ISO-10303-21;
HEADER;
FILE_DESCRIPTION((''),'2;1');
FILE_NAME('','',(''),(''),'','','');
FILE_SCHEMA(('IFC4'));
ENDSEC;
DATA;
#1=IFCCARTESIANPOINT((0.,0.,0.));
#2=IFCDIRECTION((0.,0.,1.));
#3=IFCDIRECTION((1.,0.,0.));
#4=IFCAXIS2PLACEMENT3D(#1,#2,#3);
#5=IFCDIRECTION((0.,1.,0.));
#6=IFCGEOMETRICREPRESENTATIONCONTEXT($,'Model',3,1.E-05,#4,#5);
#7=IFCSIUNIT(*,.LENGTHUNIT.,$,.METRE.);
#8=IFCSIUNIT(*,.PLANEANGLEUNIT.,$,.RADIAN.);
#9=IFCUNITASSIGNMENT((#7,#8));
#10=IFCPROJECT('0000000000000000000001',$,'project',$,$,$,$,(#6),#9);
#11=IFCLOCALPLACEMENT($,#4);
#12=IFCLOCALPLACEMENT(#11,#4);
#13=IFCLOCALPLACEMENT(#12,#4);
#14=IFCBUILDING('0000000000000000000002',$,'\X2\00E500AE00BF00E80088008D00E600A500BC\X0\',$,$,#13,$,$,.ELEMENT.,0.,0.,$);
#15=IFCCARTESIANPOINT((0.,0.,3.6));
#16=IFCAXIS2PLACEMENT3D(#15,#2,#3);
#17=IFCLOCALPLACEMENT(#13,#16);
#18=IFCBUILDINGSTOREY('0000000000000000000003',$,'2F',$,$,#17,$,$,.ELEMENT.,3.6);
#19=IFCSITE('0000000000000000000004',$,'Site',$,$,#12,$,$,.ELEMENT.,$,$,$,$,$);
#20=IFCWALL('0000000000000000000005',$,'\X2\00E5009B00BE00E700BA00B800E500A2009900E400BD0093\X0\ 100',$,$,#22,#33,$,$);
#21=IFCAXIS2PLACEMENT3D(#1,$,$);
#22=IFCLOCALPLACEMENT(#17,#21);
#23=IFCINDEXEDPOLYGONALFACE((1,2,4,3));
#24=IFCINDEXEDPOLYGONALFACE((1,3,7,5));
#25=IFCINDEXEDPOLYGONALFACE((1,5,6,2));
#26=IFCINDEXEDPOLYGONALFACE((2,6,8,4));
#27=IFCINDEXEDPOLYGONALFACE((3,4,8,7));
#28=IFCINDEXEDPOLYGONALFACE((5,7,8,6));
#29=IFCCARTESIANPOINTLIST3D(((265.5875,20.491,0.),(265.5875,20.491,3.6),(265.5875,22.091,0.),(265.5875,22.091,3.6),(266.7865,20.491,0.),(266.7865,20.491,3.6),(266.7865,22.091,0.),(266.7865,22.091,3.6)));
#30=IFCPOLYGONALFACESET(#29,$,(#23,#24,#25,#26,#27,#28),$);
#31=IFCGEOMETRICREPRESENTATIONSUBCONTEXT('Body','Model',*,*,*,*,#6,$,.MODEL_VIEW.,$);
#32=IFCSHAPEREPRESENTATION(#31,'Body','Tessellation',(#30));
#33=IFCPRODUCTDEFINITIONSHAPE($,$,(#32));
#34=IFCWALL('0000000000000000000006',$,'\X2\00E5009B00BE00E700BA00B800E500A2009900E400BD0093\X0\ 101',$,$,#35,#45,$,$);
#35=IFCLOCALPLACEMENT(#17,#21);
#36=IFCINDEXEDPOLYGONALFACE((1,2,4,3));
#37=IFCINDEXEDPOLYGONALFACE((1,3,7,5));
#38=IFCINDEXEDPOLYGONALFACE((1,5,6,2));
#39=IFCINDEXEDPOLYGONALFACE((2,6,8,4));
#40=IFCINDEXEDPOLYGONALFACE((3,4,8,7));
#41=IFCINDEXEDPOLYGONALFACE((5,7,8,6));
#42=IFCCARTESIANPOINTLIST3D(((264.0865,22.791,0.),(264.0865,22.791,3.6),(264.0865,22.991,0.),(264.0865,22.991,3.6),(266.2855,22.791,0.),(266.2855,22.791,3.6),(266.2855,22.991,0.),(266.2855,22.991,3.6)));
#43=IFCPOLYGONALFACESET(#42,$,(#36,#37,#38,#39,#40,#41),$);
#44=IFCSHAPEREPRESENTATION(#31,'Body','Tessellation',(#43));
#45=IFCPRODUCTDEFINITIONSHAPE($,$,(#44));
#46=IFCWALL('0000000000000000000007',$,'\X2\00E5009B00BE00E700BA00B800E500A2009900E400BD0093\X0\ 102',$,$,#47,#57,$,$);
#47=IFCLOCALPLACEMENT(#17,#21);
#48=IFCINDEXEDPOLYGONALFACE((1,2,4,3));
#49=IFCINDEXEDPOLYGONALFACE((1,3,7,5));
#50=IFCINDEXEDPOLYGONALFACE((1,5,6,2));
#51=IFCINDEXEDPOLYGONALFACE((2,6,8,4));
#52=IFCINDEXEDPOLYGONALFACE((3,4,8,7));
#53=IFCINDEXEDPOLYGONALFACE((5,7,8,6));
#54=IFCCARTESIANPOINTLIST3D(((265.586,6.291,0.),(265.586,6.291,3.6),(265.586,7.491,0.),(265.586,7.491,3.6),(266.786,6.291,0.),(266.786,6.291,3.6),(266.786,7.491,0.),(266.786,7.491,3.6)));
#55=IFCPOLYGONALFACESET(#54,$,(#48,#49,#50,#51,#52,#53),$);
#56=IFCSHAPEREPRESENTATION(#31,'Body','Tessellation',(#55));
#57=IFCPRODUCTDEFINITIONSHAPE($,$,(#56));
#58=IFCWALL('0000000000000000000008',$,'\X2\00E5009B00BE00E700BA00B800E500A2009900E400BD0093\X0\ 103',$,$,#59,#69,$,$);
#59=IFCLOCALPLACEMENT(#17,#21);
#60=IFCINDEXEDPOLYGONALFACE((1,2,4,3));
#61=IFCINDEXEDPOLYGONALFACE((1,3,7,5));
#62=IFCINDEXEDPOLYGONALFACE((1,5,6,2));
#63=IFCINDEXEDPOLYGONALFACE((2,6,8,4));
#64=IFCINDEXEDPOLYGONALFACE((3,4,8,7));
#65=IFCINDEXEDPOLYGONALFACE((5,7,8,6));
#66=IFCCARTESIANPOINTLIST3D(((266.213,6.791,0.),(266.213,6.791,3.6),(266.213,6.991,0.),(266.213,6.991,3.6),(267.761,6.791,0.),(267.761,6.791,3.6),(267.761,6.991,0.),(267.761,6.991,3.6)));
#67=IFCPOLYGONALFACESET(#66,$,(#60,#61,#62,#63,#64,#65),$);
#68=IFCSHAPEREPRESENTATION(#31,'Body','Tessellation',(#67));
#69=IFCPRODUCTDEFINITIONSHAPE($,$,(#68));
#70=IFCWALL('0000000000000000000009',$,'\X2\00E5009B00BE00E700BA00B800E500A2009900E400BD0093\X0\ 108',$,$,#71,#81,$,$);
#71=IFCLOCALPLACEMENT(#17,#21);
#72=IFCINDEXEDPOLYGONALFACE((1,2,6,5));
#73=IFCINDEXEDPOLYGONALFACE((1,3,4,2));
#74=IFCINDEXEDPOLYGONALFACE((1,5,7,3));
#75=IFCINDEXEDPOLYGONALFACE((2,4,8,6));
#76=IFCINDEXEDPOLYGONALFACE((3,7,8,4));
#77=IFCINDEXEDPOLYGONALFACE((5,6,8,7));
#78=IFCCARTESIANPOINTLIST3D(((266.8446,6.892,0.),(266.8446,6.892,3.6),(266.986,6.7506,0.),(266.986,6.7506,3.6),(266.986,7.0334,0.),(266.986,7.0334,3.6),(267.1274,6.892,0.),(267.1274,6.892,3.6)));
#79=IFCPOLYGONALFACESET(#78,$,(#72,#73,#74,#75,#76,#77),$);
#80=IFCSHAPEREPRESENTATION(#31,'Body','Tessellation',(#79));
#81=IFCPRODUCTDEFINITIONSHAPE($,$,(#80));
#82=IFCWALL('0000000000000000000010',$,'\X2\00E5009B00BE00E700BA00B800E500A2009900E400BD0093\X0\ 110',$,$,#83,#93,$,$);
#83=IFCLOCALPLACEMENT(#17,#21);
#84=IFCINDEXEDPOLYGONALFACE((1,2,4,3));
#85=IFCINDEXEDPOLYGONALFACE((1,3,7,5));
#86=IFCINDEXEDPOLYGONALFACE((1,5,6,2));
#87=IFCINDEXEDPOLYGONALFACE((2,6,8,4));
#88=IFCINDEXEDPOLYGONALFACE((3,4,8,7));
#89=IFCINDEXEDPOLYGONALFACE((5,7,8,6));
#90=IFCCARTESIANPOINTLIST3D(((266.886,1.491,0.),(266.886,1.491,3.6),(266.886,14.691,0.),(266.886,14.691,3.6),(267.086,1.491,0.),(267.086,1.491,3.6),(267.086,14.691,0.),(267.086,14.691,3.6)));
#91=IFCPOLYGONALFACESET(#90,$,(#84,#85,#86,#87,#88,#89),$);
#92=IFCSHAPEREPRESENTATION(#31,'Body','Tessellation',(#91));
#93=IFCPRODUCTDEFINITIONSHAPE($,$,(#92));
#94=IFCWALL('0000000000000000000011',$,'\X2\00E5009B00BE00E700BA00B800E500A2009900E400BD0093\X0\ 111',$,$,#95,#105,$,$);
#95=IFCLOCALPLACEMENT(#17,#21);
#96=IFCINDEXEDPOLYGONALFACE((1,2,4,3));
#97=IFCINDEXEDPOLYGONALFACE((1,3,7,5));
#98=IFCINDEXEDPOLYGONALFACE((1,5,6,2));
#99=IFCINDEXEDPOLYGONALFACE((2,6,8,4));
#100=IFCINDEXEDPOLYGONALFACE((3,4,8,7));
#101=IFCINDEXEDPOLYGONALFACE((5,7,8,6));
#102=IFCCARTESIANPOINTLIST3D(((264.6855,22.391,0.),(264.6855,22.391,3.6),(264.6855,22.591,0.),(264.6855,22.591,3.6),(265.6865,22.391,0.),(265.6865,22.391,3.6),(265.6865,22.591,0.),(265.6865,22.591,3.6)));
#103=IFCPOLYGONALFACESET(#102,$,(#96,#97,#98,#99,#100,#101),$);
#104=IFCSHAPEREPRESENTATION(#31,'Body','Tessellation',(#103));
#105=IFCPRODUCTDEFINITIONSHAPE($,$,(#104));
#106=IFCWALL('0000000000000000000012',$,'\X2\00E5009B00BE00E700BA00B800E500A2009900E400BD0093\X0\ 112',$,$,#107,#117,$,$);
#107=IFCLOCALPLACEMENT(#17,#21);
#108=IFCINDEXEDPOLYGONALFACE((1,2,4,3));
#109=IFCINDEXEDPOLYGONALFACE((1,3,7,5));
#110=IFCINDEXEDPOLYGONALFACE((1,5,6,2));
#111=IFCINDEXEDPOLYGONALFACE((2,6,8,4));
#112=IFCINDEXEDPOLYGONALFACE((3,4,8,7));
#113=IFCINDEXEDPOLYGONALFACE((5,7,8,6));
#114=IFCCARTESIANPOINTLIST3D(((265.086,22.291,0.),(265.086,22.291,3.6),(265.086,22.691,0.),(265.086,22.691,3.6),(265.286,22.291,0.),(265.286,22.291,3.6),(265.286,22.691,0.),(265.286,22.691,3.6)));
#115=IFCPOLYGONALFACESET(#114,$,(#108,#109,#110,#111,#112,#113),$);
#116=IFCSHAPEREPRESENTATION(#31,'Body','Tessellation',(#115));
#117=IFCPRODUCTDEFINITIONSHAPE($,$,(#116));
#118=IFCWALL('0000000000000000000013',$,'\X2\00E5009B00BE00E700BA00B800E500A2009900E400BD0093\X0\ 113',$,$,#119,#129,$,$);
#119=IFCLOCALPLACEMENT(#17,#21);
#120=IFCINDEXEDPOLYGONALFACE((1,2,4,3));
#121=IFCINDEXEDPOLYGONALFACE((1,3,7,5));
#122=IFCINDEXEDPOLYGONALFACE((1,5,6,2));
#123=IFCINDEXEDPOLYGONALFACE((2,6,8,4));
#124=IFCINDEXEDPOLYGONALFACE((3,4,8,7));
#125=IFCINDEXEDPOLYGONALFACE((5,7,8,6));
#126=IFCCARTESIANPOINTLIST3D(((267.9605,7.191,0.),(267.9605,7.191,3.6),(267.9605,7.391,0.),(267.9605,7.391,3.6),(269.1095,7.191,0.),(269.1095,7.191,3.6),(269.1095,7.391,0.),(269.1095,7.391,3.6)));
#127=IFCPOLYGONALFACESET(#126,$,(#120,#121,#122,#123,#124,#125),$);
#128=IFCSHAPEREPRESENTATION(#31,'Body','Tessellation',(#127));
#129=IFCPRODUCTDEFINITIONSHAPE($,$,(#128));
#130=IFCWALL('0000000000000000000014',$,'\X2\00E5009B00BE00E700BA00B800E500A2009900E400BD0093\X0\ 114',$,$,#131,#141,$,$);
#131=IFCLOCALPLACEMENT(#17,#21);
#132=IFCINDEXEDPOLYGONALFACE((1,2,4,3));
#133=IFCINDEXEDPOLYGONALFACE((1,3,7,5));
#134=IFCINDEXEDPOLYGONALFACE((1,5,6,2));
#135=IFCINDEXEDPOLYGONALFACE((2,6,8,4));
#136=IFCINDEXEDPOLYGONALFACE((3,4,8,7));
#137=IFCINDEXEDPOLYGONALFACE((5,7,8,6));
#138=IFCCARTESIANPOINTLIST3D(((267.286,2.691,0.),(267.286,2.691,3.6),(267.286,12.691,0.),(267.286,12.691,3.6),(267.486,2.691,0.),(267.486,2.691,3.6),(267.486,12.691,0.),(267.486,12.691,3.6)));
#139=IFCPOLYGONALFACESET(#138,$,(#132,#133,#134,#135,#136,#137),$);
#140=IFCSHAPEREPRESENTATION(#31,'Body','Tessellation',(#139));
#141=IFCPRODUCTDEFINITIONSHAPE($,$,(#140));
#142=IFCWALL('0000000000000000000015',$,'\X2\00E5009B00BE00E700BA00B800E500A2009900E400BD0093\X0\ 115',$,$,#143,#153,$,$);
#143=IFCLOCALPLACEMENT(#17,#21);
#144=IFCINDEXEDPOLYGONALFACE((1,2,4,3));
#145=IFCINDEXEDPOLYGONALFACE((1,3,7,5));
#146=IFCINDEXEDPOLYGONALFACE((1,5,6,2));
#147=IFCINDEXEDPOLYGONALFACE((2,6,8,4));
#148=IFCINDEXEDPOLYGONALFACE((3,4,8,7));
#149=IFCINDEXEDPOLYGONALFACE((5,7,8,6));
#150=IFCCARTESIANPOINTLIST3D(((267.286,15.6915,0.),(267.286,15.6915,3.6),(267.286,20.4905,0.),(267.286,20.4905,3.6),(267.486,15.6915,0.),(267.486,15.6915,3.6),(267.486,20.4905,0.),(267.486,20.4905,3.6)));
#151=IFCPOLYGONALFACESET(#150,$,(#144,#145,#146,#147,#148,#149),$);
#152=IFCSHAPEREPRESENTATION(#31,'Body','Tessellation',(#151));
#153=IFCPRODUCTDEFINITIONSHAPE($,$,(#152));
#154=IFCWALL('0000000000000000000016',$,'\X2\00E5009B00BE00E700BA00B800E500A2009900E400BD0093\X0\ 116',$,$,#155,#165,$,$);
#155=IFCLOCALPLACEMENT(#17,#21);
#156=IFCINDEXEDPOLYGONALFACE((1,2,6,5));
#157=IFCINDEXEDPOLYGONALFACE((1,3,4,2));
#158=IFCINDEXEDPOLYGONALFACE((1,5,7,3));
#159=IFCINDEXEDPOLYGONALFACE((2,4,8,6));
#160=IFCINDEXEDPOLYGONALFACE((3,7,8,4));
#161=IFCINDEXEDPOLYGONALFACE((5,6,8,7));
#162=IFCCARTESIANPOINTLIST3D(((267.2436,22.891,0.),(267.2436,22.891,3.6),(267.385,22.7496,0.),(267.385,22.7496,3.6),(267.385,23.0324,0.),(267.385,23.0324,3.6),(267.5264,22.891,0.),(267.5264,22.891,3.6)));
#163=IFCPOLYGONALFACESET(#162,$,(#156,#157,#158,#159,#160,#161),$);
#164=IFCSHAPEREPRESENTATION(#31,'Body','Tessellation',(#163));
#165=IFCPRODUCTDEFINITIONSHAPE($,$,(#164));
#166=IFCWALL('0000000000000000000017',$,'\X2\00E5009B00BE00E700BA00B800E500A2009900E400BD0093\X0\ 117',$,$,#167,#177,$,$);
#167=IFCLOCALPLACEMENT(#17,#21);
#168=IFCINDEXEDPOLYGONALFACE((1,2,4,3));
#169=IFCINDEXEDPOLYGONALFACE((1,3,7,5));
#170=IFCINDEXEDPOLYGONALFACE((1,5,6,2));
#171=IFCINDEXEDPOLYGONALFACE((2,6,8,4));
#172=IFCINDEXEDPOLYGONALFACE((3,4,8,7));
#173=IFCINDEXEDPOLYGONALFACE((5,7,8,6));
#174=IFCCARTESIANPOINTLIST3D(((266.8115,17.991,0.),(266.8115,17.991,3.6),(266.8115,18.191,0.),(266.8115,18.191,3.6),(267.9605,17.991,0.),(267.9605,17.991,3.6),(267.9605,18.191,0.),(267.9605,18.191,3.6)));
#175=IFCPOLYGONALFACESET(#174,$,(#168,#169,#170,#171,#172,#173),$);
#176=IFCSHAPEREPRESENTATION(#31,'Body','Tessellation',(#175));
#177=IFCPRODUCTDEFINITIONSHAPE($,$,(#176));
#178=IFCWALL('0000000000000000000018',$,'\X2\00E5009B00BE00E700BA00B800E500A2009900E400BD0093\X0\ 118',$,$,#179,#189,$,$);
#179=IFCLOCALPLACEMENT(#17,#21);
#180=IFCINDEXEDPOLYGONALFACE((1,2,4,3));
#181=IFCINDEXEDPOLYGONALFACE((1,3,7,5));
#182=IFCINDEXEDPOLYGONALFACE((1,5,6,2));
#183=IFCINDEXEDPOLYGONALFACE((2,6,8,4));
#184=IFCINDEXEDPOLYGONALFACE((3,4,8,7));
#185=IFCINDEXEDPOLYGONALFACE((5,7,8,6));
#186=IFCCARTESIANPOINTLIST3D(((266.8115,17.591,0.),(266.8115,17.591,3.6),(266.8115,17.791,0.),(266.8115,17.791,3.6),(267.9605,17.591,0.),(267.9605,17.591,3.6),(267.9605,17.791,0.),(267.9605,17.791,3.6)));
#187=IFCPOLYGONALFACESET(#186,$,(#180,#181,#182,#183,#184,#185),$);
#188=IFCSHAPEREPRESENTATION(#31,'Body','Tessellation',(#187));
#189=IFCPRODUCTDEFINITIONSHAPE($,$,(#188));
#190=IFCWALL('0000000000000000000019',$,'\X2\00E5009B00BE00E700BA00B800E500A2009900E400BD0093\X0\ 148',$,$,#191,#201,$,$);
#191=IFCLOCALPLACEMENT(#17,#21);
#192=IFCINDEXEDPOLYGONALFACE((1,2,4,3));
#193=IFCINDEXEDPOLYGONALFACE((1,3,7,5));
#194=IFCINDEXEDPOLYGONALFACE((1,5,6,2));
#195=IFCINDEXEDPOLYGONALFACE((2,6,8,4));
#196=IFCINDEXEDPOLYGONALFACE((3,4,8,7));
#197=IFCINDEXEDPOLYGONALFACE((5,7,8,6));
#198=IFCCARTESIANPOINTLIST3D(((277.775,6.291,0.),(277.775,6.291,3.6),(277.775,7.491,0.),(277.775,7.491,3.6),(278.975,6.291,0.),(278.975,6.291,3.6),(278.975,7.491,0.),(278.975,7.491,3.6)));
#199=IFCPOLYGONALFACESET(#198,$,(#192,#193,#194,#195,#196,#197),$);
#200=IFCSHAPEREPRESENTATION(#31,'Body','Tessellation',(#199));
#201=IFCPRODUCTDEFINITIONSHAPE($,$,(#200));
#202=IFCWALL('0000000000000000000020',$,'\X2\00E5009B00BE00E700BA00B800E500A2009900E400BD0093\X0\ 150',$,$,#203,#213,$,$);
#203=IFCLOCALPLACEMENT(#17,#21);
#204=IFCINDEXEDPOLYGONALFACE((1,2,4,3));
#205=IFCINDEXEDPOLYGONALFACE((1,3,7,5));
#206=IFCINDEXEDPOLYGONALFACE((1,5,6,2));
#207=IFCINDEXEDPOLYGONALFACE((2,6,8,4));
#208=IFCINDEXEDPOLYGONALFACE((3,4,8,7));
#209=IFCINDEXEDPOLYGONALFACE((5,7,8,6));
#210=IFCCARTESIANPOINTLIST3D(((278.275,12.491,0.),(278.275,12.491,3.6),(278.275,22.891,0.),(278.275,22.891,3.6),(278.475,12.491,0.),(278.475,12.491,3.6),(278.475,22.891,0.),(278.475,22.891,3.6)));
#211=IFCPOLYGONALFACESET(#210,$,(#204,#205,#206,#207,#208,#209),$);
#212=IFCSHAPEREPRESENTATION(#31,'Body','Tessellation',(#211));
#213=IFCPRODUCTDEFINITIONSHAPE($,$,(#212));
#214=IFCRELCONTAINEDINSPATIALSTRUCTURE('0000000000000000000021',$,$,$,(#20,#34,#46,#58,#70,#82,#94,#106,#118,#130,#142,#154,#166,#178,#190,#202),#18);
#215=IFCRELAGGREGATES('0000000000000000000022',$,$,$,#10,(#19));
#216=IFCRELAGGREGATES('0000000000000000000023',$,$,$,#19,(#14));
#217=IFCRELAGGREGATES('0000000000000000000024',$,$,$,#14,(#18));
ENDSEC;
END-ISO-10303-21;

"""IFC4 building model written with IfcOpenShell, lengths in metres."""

from ifc_helpers import new_model, si_unit, direction, frame, frame_2d, origin_with_axes, place, context, subcontext, project, spatial, rectangle, extrude, element, save


model = new_model("IFC4")

# Units and contexts
model_context = context("Model", 3, precision=1e-05, world=origin_with_axes(), true_north=direction((0.0, 1.0, 0.0)))
body_context = subcontext(model_context, "Body", "Model", "MODEL_VIEW")
ifc_project = project(units=[si_unit("LENGTHUNIT", "METRE"), si_unit("PLANEANGLEUNIT", "RADIAN")], contexts=[model_context])

# Site, building, storey
placement = place(None, origin_with_axes())
site_placement = place(placement, origin_with_axes())
site = spatial("IfcSite", under=ifc_project, at=site_placement, Name="Site", CompositionType="ELEMENT")
building_placement = place(site_placement, origin_with_axes())
building = spatial("IfcBuilding", under=site, at=building_placement, Name="å®¿è\u0088\u008dæ¥¼", CompositionType="ELEMENT", ElevationOfRefHeight=0.0, ElevationOfTerrain=0.0)
storey_placement = place(building_placement, frame((0.0, 0.0, 3.6), z_axis=(0.0, 0.0, 1.0), x_axis=(1.0, 0.0, 0.0)))
storey = spatial("IfcBuildingStorey", under=building, at=storey_placement, Name="2F", CompositionType="ELEMENT", Elevation=3.6)

# Walls
wall_1_placement = place(storey_placement, frame((266.187, 21.291, 0.0), z_axis=(0.0, 0.0, 1.0), x_axis=(1.0, 0.0, 0.0)))
element("IfcWall", 1, at=wall_1_placement, inside=storey, Name="å\u009b¾çº¸å¢\u0099ä½\u0093 100", context=body_context, shape_type="SweptSolid", body=[
    extrude(rectangle(XDim=1.199, YDim=1.6, at=frame_2d((0.0, 0.0), x_axis=(1.0, 0.0, 0.0))), frame((0.0, 0.0, 0.0), z_axis=(0.0, 0.0, 1.0)), (0.0, 0.0, 1.0), 3.6),
])
wall_2_placement = place(storey_placement, frame((265.186, 22.891, 0.0), z_axis=(0.0, 0.0, 1.0), x_axis=(1.0, 0.0, 0.0)))
element("IfcWall", 2, at=wall_2_placement, inside=storey, Name="å\u009b¾çº¸å¢\u0099ä½\u0093 101", context=body_context, shape_type="SweptSolid", body=[
    extrude(rectangle(XDim=2.199, YDim=0.2, at=frame_2d((0.0, 0.0), x_axis=(1.0, 0.0, 0.0))), frame((0.0, 0.0, 0.0), z_axis=(0.0, 0.0, 1.0)), (0.0, 0.0, 1.0), 3.6),
])
wall_3_placement = place(storey_placement, frame((266.186, 6.891, 0.0), z_axis=(0.0, 0.0, 1.0), x_axis=(1.0, 0.0, 0.0)))
element("IfcWall", 3, at=wall_3_placement, inside=storey, Name="å\u009b¾çº¸å¢\u0099ä½\u0093 102", context=body_context, shape_type="SweptSolid", body=[
    extrude(rectangle(XDim=1.2, YDim=1.2, at=frame_2d((0.0, 0.0), x_axis=(1.0, 0.0, 0.0))), frame((0.0, 0.0, 0.0), z_axis=(0.0, 0.0, 1.0)), (0.0, 0.0, 1.0), 3.6),
])
wall_4_placement = place(storey_placement, frame((266.987, 6.891, 0.0), z_axis=(0.0, 0.0, 1.0), x_axis=(1.0, 0.0, 0.0)))
element("IfcWall", 4, at=wall_4_placement, inside=storey, Name="å\u009b¾çº¸å¢\u0099ä½\u0093 103", context=body_context, shape_type="SweptSolid", body=[
    extrude(rectangle(XDim=1.548, YDim=0.2, at=frame_2d((0.0, 0.0), x_axis=(1.0, 0.0, 0.0))), frame((0.0, 0.0, 0.0), z_axis=(0.0, 0.0, 1.0)), (0.0, 0.0, 1.0), 3.6),
])
wall_5_placement = place(storey_placement, frame((266.986, 6.892, 0.0), z_axis=(0.0, 0.0, 1.0), x_axis=(0.707107, -0.707107, 0.0)))
element("IfcWall", 5, at=wall_5_placement, inside=storey, Name="å\u009b¾çº¸å¢\u0099ä½\u0093 108", context=body_context, shape_type="SweptSolid", body=[
    extrude(rectangle(XDim=0.2, YDim=0.2, at=frame_2d((0.0, 0.0), x_axis=(1.0, 0.0, 0.0))), frame((0.0, 0.0, 0.0), z_axis=(0.0, 0.0, 1.0)), (0.0, 0.0, 1.0), 3.6),
])
wall_6_placement = place(storey_placement, frame((266.986, 8.091, 0.0), z_axis=(0.0, 0.0, 1.0), x_axis=(0.0, 1.0, 0.0)))
element("IfcWall", 6, at=wall_6_placement, inside=storey, Name="å\u009b¾çº¸å¢\u0099ä½\u0093 110", context=body_context, shape_type="SweptSolid", body=[
    extrude(rectangle(XDim=13.2, YDim=0.2, at=frame_2d((0.0, 0.0), x_axis=(1.0, 0.0, 0.0))), frame((0.0, 0.0, 0.0), z_axis=(0.0, 0.0, 1.0)), (0.0, 0.0, 1.0), 3.6),
])
wall_7_placement = place(storey_placement, frame((265.186, 22.491, 0.0), z_axis=(0.0, 0.0, 1.0), x_axis=(1.0, 0.0, 0.0)))
element("IfcWall", 7, at=wall_7_placement, inside=storey, Name="å\u009b¾çº¸å¢\u0099ä½\u0093 111", context=body_context, shape_type="SweptSolid", body=[
    extrude(rectangle(XDim=1.001, YDim=0.2, at=frame_2d((0.0, 0.0), x_axis=(1.0, 0.0, 0.0))), frame((0.0, 0.0, 0.0), z_axis=(0.0, 0.0, 1.0)), (0.0, 0.0, 1.0), 3.6),
])
wall_8_placement = place(storey_placement, frame((265.186, 22.491, 0.0), z_axis=(0.0, 0.0, 1.0), x_axis=(0.0, 1.0, 0.0)))
element("IfcWall", 8, at=wall_8_placement, inside=storey, Name="å\u009b¾çº¸å¢\u0099ä½\u0093 112", context=body_context, shape_type="SweptSolid", body=[
    extrude(rectangle(XDim=0.4, YDim=0.2, at=frame_2d((0.0, 0.0), x_axis=(1.0, 0.0, 0.0))), frame((0.0, 0.0, 0.0), z_axis=(0.0, 0.0, 1.0)), (0.0, 0.0, 1.0), 3.6),
])
wall_9_placement = place(storey_placement, frame((268.535, 7.291, 0.0), z_axis=(0.0, 0.0, 1.0), x_axis=(-1.0, 0.0, 0.0)))
element("IfcWall", 9, at=wall_9_placement, inside=storey, Name="å\u009b¾çº¸å¢\u0099ä½\u0093 113", context=body_context, shape_type="SweptSolid", body=[
    extrude(rectangle(XDim=1.149, YDim=0.2, at=frame_2d((0.0, 0.0), x_axis=(1.0, 0.0, 0.0))), frame((0.0, 0.0, 0.0), z_axis=(0.0, 0.0, 1.0)), (0.0, 0.0, 1.0), 3.6),
])
wall_10_placement = place(storey_placement, frame((267.386, 7.691, 0.0), z_axis=(0.0, 0.0, 1.0), x_axis=(0.0, 1.0, 0.0)))
element("IfcWall", 10, at=wall_10_placement, inside=storey, Name="å\u009b¾çº¸å¢\u0099ä½\u0093 114", context=body_context, shape_type="SweptSolid", body=[
    extrude(rectangle(XDim=10.0, YDim=0.2, at=frame_2d((0.0, 0.0), x_axis=(1.0, 0.0, 0.0))), frame((0.0, 0.0, 0.0), z_axis=(0.0, 0.0, 1.0)), (0.0, 0.0, 1.0), 3.6),
])
wall_11_placement = place(storey_placement, frame((267.386, 18.091, 0.0), z_axis=(0.0, 0.0, 1.0), x_axis=(0.0, 1.0, 0.0)))
element("IfcWall", 11, at=wall_11_placement, inside=storey, Name="å\u009b¾çº¸å¢\u0099ä½\u0093 115", context=body_context, shape_type="SweptSolid", body=[
    extrude(rectangle(XDim=4.799, YDim=0.2, at=frame_2d((0.0, 0.0), x_axis=(1.0, 0.0, 0.0))), frame((0.0, 0.0, 0.0), z_axis=(0.0, 0.0, 1.0)), (0.0, 0.0, 1.0), 3.6),
])
wall_12_placement = place(storey_placement, frame((267.385, 22.891, 0.0), z_axis=(0.0, 0.0, 1.0), x_axis=(0.707107, -0.707107, 0.0)))
element("IfcWall", 12, at=wall_12_placement, inside=storey, Name="å\u009b¾çº¸å¢\u0099ä½\u0093 116", context=body_context, shape_type="SweptSolid", body=[
    extrude(rectangle(XDim=0.2, YDim=0.2, at=frame_2d((0.0, 0.0), x_axis=(1.0, 0.0, 0.0))), frame((0.0, 0.0, 0.0), z_axis=(0.0, 0.0, 1.0)), (0.0, 0.0, 1.0), 3.6),
])
for number, where, z_axis, x_axis, name in (
    (13, (267.386, 18.091, 0.0), (0.0, 0.0, 1.0), (1.0, 0.0, 0.0), "å\u009b¾çº¸å¢\u0099ä½\u0093 117"),
    (14, (267.386, 17.691, 0.0), (0.0, 0.0, 1.0), (1.0, 0.0, 0.0), "å\u009b¾çº¸å¢\u0099ä½\u0093 118"),
):
    element("IfcWall", number, at=place(storey_placement, frame(where, z_axis=z_axis, x_axis=x_axis)), inside=storey, Name=name, context=body_context, shape_type="SweptSolid", body=[
        extrude(rectangle(XDim=1.149, YDim=0.2, at=frame_2d((0.0, 0.0), x_axis=(1.0, 0.0, 0.0))), frame((0.0, 0.0, 0.0), z_axis=(0.0, 0.0, 1.0)), (0.0, 0.0, 1.0), 3.6),
    ])
wall_13_placement = place(storey_placement, frame((278.375, 6.891, 0.0), z_axis=(0.0, 0.0, 1.0), x_axis=(1.0, 0.0, 0.0)))
element("IfcWall", 15, at=wall_13_placement, inside=storey, Name="å\u009b¾çº¸å¢\u0099ä½\u0093 148", context=body_context, shape_type="SweptSolid", body=[
    extrude(rectangle(XDim=1.2, YDim=1.2, at=frame_2d((0.0, 0.0), x_axis=(1.0, 0.0, 0.0))), frame((0.0, 0.0, 0.0), z_axis=(0.0, 0.0, 1.0)), (0.0, 0.0, 1.0), 3.6),
])
wall_14_placement = place(storey_placement, frame((278.375, 17.691, 0.0), z_axis=(0.0, 0.0, 1.0), x_axis=(0.0, -1.0, 0.0)))
element("IfcWall", 16, at=wall_14_placement, inside=storey, Name="å\u009b¾çº¸å¢\u0099ä½\u0093 150", context=body_context, shape_type="SweptSolid", body=[
    extrude(rectangle(XDim=10.4, YDim=0.2, at=frame_2d((0.0, 0.0), x_axis=(1.0, 0.0, 0.0))), frame((0.0, 0.0, 0.0), z_axis=(0.0, 0.0, 1.0)), (0.0, 0.0, 1.0), 3.6),
])

save(model, "model.ifc")
